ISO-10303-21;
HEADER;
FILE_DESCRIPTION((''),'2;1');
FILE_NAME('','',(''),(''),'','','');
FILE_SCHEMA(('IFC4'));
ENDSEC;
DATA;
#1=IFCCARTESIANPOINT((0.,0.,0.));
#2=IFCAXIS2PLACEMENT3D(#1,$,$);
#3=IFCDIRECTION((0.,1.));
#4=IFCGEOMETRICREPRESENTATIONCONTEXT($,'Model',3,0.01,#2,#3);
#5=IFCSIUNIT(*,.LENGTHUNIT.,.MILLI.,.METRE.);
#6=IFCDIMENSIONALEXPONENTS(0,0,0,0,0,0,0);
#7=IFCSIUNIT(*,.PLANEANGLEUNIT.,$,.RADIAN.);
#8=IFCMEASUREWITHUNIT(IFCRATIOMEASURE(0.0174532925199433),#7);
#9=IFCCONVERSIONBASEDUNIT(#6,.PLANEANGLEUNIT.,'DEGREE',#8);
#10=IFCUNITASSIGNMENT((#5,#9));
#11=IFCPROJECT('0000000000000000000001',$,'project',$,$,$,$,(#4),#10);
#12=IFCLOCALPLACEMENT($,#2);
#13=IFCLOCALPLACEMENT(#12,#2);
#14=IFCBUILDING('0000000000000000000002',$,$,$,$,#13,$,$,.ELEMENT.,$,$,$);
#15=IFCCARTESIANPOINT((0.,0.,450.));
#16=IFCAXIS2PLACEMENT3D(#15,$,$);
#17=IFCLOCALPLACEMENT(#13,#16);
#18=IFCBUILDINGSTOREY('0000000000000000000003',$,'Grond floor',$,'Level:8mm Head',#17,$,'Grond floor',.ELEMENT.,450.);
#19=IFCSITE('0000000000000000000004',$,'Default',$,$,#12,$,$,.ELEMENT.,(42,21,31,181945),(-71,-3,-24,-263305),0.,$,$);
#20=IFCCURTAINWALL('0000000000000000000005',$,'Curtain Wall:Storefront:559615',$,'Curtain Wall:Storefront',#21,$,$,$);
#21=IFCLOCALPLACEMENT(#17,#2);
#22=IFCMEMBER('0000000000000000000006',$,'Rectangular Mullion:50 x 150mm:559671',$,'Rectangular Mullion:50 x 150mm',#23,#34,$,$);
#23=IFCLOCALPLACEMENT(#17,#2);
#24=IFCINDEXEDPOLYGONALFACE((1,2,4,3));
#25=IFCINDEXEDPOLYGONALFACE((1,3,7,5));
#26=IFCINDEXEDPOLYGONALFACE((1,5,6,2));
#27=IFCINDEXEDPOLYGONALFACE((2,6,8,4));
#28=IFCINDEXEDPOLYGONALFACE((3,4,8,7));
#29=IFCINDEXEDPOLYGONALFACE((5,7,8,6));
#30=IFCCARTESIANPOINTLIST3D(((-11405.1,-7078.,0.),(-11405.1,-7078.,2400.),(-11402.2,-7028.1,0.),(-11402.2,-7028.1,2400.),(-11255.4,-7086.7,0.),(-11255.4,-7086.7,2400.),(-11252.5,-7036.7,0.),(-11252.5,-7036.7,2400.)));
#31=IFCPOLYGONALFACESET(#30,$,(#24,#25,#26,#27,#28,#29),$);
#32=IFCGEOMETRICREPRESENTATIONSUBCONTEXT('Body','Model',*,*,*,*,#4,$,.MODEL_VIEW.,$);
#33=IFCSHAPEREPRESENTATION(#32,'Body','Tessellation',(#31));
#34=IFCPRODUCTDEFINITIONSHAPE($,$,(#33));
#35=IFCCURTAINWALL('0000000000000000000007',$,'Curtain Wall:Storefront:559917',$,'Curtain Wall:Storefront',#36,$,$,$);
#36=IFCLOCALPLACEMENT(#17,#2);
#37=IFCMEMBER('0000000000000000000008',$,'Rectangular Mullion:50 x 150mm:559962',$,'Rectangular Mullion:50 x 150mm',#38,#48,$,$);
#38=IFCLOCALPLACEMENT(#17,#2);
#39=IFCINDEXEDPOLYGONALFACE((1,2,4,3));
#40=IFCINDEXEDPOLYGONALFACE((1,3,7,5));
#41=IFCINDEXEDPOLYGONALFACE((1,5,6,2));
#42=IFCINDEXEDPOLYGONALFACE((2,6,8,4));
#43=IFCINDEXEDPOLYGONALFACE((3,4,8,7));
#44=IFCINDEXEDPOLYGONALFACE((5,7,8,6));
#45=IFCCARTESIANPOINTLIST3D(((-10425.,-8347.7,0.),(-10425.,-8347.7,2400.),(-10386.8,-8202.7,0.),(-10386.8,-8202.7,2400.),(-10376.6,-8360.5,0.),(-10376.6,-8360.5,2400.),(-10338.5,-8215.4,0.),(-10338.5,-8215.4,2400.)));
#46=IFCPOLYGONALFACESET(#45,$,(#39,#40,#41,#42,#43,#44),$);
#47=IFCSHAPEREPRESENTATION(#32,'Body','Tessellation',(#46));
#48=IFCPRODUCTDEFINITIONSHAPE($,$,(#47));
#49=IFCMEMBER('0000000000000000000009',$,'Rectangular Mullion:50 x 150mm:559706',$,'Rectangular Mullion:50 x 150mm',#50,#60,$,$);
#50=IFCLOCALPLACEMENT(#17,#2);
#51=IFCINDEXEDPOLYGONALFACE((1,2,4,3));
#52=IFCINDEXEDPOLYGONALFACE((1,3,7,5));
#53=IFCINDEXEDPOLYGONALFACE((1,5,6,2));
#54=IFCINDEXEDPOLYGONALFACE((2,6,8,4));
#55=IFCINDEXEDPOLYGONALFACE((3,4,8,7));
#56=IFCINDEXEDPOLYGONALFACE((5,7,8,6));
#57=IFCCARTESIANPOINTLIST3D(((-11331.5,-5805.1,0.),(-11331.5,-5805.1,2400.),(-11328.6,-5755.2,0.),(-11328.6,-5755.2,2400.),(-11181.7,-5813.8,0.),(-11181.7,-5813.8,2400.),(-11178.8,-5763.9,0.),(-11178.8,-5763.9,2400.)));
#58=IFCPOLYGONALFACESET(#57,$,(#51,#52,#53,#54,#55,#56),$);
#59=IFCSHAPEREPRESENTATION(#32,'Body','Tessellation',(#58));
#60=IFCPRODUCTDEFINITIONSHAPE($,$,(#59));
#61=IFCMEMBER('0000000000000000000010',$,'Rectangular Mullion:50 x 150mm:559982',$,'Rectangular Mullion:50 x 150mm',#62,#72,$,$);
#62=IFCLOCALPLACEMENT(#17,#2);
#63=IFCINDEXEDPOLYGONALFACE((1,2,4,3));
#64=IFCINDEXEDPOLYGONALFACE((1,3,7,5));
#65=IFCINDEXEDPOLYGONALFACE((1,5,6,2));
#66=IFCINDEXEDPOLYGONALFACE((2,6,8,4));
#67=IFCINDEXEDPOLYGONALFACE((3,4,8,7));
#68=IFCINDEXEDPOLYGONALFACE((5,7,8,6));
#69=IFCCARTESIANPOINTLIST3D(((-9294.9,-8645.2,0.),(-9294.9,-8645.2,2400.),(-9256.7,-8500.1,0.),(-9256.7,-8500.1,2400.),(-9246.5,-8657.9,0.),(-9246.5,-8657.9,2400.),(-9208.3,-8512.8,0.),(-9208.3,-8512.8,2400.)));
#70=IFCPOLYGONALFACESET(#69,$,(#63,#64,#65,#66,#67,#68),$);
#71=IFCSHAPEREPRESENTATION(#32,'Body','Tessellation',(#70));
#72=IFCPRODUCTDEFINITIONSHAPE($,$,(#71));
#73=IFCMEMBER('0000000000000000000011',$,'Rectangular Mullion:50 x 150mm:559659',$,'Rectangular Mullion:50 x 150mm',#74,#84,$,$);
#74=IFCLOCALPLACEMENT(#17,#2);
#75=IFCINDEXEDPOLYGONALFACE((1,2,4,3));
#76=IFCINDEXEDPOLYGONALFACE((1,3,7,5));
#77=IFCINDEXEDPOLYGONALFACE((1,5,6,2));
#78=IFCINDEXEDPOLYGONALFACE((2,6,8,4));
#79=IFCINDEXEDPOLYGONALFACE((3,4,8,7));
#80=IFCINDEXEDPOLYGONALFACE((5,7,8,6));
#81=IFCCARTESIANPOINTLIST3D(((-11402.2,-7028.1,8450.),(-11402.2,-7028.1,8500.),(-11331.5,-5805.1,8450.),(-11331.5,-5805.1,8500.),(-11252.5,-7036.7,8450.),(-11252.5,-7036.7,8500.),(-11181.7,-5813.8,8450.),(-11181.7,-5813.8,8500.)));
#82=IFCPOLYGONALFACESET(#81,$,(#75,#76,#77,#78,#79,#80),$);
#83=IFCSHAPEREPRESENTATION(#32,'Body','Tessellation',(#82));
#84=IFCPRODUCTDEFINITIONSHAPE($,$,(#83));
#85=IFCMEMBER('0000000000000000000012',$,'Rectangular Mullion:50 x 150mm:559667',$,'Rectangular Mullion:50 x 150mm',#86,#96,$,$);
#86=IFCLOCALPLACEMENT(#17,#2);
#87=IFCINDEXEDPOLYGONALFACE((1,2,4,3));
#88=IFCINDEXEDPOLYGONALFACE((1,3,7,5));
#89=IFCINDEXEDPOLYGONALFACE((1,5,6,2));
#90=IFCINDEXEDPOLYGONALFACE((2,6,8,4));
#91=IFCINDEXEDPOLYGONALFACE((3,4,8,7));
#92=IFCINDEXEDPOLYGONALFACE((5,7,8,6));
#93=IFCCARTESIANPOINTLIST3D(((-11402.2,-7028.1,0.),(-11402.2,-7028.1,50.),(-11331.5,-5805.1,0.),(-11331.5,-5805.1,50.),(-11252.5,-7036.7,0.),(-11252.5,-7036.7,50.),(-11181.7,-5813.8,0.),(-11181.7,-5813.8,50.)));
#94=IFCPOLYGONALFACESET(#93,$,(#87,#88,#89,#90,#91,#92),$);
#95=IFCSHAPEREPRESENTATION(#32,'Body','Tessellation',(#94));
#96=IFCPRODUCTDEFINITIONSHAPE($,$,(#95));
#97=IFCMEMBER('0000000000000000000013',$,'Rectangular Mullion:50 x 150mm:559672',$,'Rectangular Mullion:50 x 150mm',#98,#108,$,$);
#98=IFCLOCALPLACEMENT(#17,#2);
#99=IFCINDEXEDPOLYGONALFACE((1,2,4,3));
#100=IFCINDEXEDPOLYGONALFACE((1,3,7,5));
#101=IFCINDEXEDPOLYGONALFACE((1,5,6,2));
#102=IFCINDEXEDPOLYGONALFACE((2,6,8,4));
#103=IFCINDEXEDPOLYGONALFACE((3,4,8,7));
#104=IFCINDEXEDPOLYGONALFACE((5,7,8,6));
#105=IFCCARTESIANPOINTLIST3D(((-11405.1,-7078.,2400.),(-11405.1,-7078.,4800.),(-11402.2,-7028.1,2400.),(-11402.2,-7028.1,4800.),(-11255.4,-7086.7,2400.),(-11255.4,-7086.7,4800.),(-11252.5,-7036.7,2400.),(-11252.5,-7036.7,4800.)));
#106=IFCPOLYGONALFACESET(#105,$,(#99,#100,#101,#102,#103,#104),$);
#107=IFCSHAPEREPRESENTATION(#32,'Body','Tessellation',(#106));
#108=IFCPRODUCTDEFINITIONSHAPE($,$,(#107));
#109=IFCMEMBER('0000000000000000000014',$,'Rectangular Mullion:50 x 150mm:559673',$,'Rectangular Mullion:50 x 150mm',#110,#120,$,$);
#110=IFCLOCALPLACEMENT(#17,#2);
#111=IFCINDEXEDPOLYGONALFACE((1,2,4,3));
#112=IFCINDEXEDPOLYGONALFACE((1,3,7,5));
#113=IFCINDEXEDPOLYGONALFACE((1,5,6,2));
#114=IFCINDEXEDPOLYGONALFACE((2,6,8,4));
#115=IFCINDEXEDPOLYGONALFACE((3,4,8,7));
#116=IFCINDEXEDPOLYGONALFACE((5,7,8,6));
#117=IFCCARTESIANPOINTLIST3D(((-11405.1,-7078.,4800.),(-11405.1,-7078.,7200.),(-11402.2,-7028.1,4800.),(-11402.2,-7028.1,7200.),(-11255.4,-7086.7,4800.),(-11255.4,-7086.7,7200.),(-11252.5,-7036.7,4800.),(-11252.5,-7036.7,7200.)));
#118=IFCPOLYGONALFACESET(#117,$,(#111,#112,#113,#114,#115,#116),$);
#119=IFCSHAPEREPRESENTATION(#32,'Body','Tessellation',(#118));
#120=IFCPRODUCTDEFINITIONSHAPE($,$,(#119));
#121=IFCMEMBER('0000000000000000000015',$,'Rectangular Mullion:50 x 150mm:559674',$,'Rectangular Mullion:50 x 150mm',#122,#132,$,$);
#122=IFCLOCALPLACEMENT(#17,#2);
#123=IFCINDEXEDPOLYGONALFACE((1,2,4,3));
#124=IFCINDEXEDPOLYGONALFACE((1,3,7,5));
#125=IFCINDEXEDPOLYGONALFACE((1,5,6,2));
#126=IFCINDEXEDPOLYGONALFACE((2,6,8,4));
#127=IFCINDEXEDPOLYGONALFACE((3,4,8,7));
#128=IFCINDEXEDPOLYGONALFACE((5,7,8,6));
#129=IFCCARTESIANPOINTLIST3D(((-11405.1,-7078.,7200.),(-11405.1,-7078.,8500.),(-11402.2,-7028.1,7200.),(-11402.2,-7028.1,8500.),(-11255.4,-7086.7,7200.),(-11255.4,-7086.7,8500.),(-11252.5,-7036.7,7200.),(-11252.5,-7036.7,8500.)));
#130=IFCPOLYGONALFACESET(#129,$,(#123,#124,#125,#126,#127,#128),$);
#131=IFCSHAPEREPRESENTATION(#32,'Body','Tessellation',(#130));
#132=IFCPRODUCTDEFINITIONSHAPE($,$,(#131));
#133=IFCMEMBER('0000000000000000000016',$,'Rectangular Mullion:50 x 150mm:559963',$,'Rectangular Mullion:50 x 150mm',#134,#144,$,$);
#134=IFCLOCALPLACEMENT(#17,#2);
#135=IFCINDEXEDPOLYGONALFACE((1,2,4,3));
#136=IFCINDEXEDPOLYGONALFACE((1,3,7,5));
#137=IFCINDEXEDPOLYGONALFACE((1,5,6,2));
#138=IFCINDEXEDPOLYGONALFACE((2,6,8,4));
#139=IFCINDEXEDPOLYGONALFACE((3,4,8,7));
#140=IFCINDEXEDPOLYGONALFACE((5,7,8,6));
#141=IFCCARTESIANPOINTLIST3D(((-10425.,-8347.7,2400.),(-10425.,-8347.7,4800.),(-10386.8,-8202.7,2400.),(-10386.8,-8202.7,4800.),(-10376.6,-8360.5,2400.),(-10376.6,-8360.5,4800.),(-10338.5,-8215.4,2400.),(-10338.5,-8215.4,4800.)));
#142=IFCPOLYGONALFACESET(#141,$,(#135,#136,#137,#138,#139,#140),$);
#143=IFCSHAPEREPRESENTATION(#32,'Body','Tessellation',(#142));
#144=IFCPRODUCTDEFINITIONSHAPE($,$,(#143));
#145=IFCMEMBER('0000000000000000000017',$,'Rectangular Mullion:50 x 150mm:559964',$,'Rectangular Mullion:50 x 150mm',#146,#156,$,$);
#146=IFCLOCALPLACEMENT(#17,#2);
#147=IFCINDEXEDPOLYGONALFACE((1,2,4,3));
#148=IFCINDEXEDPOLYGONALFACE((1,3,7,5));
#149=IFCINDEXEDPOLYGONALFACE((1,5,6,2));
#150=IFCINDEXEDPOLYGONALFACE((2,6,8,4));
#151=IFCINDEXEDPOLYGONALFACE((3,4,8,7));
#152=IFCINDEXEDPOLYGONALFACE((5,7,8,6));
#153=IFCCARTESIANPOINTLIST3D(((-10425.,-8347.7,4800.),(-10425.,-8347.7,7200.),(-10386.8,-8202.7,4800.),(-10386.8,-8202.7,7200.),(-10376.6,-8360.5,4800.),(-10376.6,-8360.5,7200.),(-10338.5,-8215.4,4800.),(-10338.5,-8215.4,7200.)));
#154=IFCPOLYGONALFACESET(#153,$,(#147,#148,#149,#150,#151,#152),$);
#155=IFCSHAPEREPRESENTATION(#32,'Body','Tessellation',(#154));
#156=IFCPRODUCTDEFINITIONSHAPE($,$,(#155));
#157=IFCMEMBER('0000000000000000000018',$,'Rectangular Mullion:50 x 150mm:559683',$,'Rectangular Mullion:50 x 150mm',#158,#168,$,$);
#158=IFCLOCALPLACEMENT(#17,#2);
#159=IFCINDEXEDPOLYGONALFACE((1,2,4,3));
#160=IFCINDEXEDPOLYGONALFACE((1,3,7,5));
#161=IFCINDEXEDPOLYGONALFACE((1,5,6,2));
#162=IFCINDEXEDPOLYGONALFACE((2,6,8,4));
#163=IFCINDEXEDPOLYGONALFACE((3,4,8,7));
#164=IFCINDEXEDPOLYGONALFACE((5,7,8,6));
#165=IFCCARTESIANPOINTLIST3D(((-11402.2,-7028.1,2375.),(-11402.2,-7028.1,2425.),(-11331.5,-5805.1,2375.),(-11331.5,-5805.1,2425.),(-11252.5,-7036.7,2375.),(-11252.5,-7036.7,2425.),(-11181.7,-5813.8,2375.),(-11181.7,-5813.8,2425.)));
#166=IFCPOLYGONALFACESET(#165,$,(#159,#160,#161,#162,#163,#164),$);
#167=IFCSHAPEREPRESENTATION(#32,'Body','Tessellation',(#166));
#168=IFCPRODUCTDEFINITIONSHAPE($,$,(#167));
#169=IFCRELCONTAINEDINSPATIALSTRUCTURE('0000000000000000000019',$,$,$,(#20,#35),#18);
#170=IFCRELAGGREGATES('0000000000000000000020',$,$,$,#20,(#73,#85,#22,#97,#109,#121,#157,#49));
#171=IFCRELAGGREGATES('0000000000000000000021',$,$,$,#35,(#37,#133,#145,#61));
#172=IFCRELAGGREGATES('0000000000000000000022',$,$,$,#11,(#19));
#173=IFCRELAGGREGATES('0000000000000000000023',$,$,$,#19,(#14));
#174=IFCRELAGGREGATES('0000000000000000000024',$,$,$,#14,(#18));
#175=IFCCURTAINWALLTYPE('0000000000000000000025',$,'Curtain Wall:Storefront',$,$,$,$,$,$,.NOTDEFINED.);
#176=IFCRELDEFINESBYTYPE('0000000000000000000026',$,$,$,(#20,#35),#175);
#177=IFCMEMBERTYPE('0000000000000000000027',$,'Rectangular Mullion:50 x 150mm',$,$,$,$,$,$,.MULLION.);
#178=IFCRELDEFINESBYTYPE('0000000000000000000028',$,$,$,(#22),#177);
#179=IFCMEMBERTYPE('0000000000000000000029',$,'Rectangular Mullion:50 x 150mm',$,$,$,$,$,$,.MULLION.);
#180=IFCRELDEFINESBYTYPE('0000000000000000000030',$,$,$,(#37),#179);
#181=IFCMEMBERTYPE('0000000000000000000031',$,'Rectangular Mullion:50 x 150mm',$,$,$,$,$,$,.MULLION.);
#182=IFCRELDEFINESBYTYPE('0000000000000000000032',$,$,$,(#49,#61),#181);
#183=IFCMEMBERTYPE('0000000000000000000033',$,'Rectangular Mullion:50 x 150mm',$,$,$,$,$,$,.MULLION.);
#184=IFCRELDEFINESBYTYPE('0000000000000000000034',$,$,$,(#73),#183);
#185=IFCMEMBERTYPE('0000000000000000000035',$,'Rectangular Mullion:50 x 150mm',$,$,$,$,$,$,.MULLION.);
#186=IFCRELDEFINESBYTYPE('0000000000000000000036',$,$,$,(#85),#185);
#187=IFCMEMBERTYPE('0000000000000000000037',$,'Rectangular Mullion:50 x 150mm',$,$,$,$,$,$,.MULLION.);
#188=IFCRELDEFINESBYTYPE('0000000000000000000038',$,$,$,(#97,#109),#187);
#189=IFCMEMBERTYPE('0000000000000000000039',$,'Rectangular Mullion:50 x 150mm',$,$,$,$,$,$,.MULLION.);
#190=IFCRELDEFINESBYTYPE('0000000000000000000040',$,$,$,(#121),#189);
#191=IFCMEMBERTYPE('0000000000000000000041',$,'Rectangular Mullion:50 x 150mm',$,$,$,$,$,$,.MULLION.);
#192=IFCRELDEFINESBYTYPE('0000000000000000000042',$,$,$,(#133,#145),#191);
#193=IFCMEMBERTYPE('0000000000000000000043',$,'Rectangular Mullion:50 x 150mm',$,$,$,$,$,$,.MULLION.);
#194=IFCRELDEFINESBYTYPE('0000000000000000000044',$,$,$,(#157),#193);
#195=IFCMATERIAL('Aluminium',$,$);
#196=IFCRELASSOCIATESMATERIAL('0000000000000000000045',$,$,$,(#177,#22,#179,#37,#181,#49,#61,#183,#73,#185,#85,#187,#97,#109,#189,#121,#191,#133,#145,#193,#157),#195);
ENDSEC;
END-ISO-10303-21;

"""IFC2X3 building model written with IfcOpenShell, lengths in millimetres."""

from ifc_helpers import new_model, entity, si_unit, converted_unit, direction, frame, origin, origin_2d_with_axis, place, context, subcontext, project, spatial, rectangle, extrude, source, transform, mapped, material, type_object, type_shapes, element, aggregate, save


model = new_model("IFC2X3")

# Units and contexts
model_context = context("Model", 3, precision=0.01, world=origin(), true_north=direction((0.0, 1.0)))
body_context = subcontext(model_context, "Body", "Model", "MODEL_VIEW")
ifc_project = project(units=[si_unit("LENGTHUNIT", "METRE", prefix="MILLI"), converted_unit("PLANEANGLEUNIT", "DEGREE", entity("IfcRatioMeasure", 0.0174532925199433), si_unit("PLANEANGLEUNIT", "RADIAN"), dimensions=[0, 0, 0, 0, 0, 0, 0])], contexts=[model_context])

# Site, building, storey
site_placement = place(None, origin())
site = spatial("IfcSite", under=ifc_project, at=site_placement, Name="Default", CompositionType="ELEMENT", RefLatitude=(42, 21, 31, 181945), RefLongitude=(-71, -3, -24, -263305), RefElevation=0.0)
building_placement = place(site_placement, origin())
building = spatial("IfcBuilding", under=site, at=building_placement, CompositionType="ELEMENT")
storey_placement = place(building_placement, frame((0.0, 0.0, 450.0)))
storey = spatial("IfcBuildingStorey", under=building, at=storey_placement, Name="Grond floor", ObjectType="Level:8mm Head", LongName="Grond floor", CompositionType="ELEMENT", Elevation=450.0)

# Curtain walls, members
curtain_wall_type = type_object("IfcCurtainWallType", Name="Curtain Wall:Storefront", PredefinedType="NOTDEFINED")
curtain_wall_1_placement = place(storey_placement, frame((0.0, 0.0, -450.0)))
curtain_wall_1 = element("IfcCurtainWall", 1, at=curtain_wall_1_placement, inside=storey, type_object=curtain_wall_type, Name="Curtain Wall:Storefront:559615", ObjectType="Curtain Wall:Storefront")
ifc_material_1 = material(Name="Aluminium")
member_type_1 = type_object("IfcMemberType", Name="Rectangular Mullion:50 x 150mm", PredefinedType="MULLION", material=ifc_material_1)
shared_shape_1 = source(origin(), body_context, "Body", "SweptSolid", [
    extrude(rectangle(XDim=150.0, YDim=50.0, at=origin_2d_with_axis()), frame((-25.0, 0.0, -2400.0), z_axis=(0.0, 0.0, 1.0), x_axis=(0.0, -1.0, 0.0)), (0.0, 0.0, 1.0), 2400.0),
])
type_shapes(member_type_1, [shared_shape_1])
member_1_placement = place(storey_placement, frame((-11330.2, -7082.3, 0.0), z_axis=(0.0, 0.0, -1.0), x_axis=(-0.057751, -0.998331, 0.0)))
member_1 = element("IfcMember", 2, at=member_1_placement, type_object=member_type_1, material=ifc_material_1, Name="Rectangular Mullion:50 x 150mm:559671", ObjectType="Rectangular Mullion:50 x 150mm", context=body_context, shape_type="MappedRepresentation", body=[
    mapped(shared_shape_1, transform((0.0, 0.0, 0.0), scale=1.0)),
])
curtain_wall_2_placement = place(storey_placement, frame((0.0, 0.0, -450.0)))
curtain_wall_2 = element("IfcCurtainWall", 3, at=curtain_wall_2_placement, inside=storey, type_object=curtain_wall_type, Name="Curtain Wall:Storefront:559917", ObjectType="Curtain Wall:Storefront")
member_type_2 = type_object("IfcMemberType", Name="Rectangular Mullion:50 x 150mm", PredefinedType="MULLION", material=ifc_material_1)
shared_shape_2 = source(origin(), body_context, "Body", "SweptSolid", [
    extrude(rectangle(XDim=150.0, YDim=50.0, at=origin_2d_with_axis()), frame((-25.0, 0.0, -2400.0), z_axis=(0.0, 0.0, 1.0), x_axis=(0.0, -1.0, 0.0)), (0.0, 0.0, 1.0), 2400.0),
])
type_shapes(member_type_2, [shared_shape_2])
member_2_placement = place(storey_placement, frame((-10405.9, -8275.2, 2400.0), z_axis=(0.0, 0.0, 1.0), x_axis=(-0.967067, 0.25452, 0.0)))
member_2 = element("IfcMember", 4, at=member_2_placement, type_object=member_type_2, material=ifc_material_1, Name="Rectangular Mullion:50 x 150mm:559962", ObjectType="Rectangular Mullion:50 x 150mm", context=body_context, shape_type="MappedRepresentation", body=[
    mapped(shared_shape_2, transform((0.0, 0.0, 0.0), scale=1.0)),
])

# Members
member_type_3 = type_object("IfcMemberType", Name="Rectangular Mullion:50 x 150mm", PredefinedType="MULLION", material=ifc_material_1)
shared_shape_3 = source(origin(), body_context, "Body", "SweptSolid", [
    extrude(rectangle(XDim=150.0, YDim=50.0, at=origin_2d_with_axis()), frame((0.0, 0.0, -2400.0), z_axis=(0.0, 0.0, 1.0), x_axis=(0.0, -1.0, 0.0)), (0.0, 0.0, 1.0), 2400.0),
])
type_shapes(member_type_3, [shared_shape_3])
member_3_placement = place(storey_placement, frame((-11255.2, -5784.5, 0.0), z_axis=(0.0, 0.0, -1.0), x_axis=(-0.057751, -0.998331, 0.0)))
member_3 = element("IfcMember", 5, at=member_3_placement, type_object=member_type_3, material=ifc_material_1, Name="Rectangular Mullion:50 x 150mm:559706", ObjectType="Rectangular Mullion:50 x 150mm", context=body_context, shape_type="MappedRepresentation", body=[
    mapped(shared_shape_3, transform((0.0, 0.0, 0.0), scale=1.0)),
])
member_4_placement = place(storey_placement, frame((-9251.6, -8579.0, 0.0), z_axis=(0.0, 0.0, -1.0), x_axis=(0.967067, -0.25452, 0.0)))
member_4 = element("IfcMember", 6, at=member_4_placement, type_object=member_type_3, material=ifc_material_1, Name="Rectangular Mullion:50 x 150mm:559982", ObjectType="Rectangular Mullion:50 x 150mm", context=body_context, shape_type="MappedRepresentation", body=[
    mapped(shared_shape_3, transform((0.0, 0.0, 0.0), scale=1.0)),
])
member_type_4 = type_object("IfcMemberType", Name="Rectangular Mullion:50 x 150mm", PredefinedType="MULLION", material=ifc_material_1)
shared_shape_4 = source(origin(), body_context, "Body", "SweptSolid", [
    extrude(rectangle(XDim=150.0, YDim=50.0, at=origin_2d_with_axis()), frame((-25.0, 0.0, -1225.0), z_axis=(0.0, 0.0, 1.0), x_axis=(0.0, -1.0, 0.0)), (0.0, 0.0, 1.0), 1225.0),
])
type_shapes(member_type_4, [shared_shape_4])
member_5_placement = place(storey_placement, frame((-11327.4, -7032.4, 8500.0), z_axis=(-0.057751, -0.998331, 0.0), x_axis=(0.0, 0.0, 1.0)))
member_5 = element("IfcMember", 7, at=member_5_placement, type_object=member_type_4, material=ifc_material_1, Name="Rectangular Mullion:50 x 150mm:559659", ObjectType="Rectangular Mullion:50 x 150mm", context=body_context, shape_type="MappedRepresentation", body=[
    mapped(shared_shape_4, transform((0.0, 0.0, 0.0), scale=1.0)),
])
member_type_5 = type_object("IfcMemberType", Name="Rectangular Mullion:50 x 150mm", PredefinedType="MULLION", material=ifc_material_1)
shared_shape_5 = source(origin(), body_context, "Body", "SweptSolid", [
    extrude(rectangle(XDim=150.0, YDim=50.0, at=origin_2d_with_axis()), frame((-25.0, 0.0, -1225.0), z_axis=(0.0, 0.0, 1.0), x_axis=(0.0, -1.0, 0.0)), (0.0, 0.0, 1.0), 1225.0),
])
type_shapes(member_type_5, [shared_shape_5])
member_6_placement = place(storey_placement, frame((-11256.6, -5809.4, 0.0), z_axis=(0.057751, 0.998331, 0.0), x_axis=(0.0, 0.0, -1.0)))
member_6 = element("IfcMember", 8, at=member_6_placement, type_object=member_type_5, material=ifc_material_1, Name="Rectangular Mullion:50 x 150mm:559667", ObjectType="Rectangular Mullion:50 x 150mm", context=body_context, shape_type="MappedRepresentation", body=[
    mapped(shared_shape_5, transform((0.0, 0.0, 0.0), scale=1.0)),
])
member_type_6 = type_object("IfcMemberType", Name="Rectangular Mullion:50 x 150mm", PredefinedType="MULLION", material=ifc_material_1)
shared_shape_6 = source(origin(), body_context, "Body", "SweptSolid", [
    extrude(rectangle(XDim=150.0, YDim=50.0, at=origin_2d_with_axis()), frame((-25.0, 0.0, -2400.0), z_axis=(0.0, 0.0, 1.0), x_axis=(0.0, -1.0, 0.0)), (0.0, 0.0, 1.0), 2400.0),
])
type_shapes(member_type_6, [shared_shape_6])
member_7_placement = place(storey_placement, frame((-11330.2, -7082.3, 2400.0), z_axis=(0.0, 0.0, -1.0), x_axis=(-0.057751, -0.998331, 0.0)))
member_7 = element("IfcMember", 9, at=member_7_placement, type_object=member_type_6, material=ifc_material_1, Name="Rectangular Mullion:50 x 150mm:559672", ObjectType="Rectangular Mullion:50 x 150mm", context=body_context, shape_type="MappedRepresentation", body=[
    mapped(shared_shape_6, transform((0.0, 0.0, 0.0), scale=1.0)),
])
member_8_placement = place(storey_placement, frame((-11330.2, -7082.3, 4800.0), z_axis=(0.0, 0.0, -1.0), x_axis=(-0.057751, -0.998331, 0.0)))
member_8 = element("IfcMember", 10, at=member_8_placement, type_object=member_type_6, material=ifc_material_1, Name="Rectangular Mullion:50 x 150mm:559673", ObjectType="Rectangular Mullion:50 x 150mm", context=body_context, shape_type="MappedRepresentation", body=[
    mapped(shared_shape_6, transform((0.0, 0.0, 0.0), scale=1.0)),
])
member_type_7 = type_object("IfcMemberType", Name="Rectangular Mullion:50 x 150mm", PredefinedType="MULLION", material=ifc_material_1)
shared_shape_7 = source(origin(), body_context, "Body", "SweptSolid", [
    extrude(rectangle(XDim=150.0, YDim=50.0, at=origin_2d_with_axis()), frame((-25.0, 0.0, -1300.0), z_axis=(0.0, 0.0, 1.0), x_axis=(0.0, -1.0, 0.0)), (0.0, 0.0, 1.0), 1300.0),
])
type_shapes(member_type_7, [shared_shape_7])
member_9_placement = place(storey_placement, frame((-11330.2, -7082.3, 7200.0), z_axis=(0.0, 0.0, -1.0), x_axis=(-0.057751, -0.998331, 0.0)))
member_9 = element("IfcMember", 11, at=member_9_placement, type_object=member_type_7, material=ifc_material_1, Name="Rectangular Mullion:50 x 150mm:559674", ObjectType="Rectangular Mullion:50 x 150mm", context=body_context, shape_type="MappedRepresentation", body=[
    mapped(shared_shape_7, transform((0.0, 0.0, 0.0), scale=1.0)),
])
member_type_8 = type_object("IfcMemberType", Name="Rectangular Mullion:50 x 150mm", PredefinedType="MULLION", material=ifc_material_1)
shared_shape_8 = source(origin(), body_context, "Body", "SweptSolid", [
    extrude(rectangle(XDim=150.0, YDim=50.0, at=origin_2d_with_axis()), frame((-25.0, 0.0, -2400.0), z_axis=(0.0, 0.0, 1.0), x_axis=(0.0, -1.0, 0.0)), (0.0, 0.0, 1.0), 2400.0),
])
type_shapes(member_type_8, [shared_shape_8])
member_10_placement = place(storey_placement, frame((-10405.9, -8275.2, 4800.0), z_axis=(0.0, 0.0, 1.0), x_axis=(-0.967067, 0.25452, 0.0)))
member_10 = element("IfcMember", 12, at=member_10_placement, type_object=member_type_8, material=ifc_material_1, Name="Rectangular Mullion:50 x 150mm:559963", ObjectType="Rectangular Mullion:50 x 150mm", context=body_context, shape_type="MappedRepresentation", body=[
    mapped(shared_shape_8, transform((0.0, 0.0, 0.0), scale=1.0)),
])
member_11_placement = place(storey_placement, frame((-10405.9, -8275.2, 7200.0), z_axis=(0.0, 0.0, 1.0), x_axis=(-0.967067, 0.25452, 0.0)))
member_11 = element("IfcMember", 13, at=member_11_placement, type_object=member_type_8, material=ifc_material_1, Name="Rectangular Mullion:50 x 150mm:559964", ObjectType="Rectangular Mullion:50 x 150mm", context=body_context, shape_type="MappedRepresentation", body=[
    mapped(shared_shape_8, transform((0.0, 0.0, 0.0), scale=1.0)),
])
member_type_9 = type_object("IfcMemberType", Name="Rectangular Mullion:50 x 150mm", PredefinedType="MULLION", material=ifc_material_1)
shared_shape_9 = source(origin(), body_context, "Body", "SweptSolid", [
    extrude(rectangle(XDim=150.0, YDim=50.0, at=origin_2d_with_axis()), frame((0.0, 0.0, -1225.0), z_axis=(0.0, 0.0, 1.0), x_axis=(0.0, -1.0, 0.0)), (0.0, 0.0, 1.0), 1225.0),
])
type_shapes(member_type_9, [shared_shape_9])
member_12_placement = place(storey_placement, frame((-11327.4, -7032.4, 2400.0), z_axis=(-0.057751, -0.998331, 0.0), x_axis=(0.0, 0.0, 1.0)))
member_12 = element("IfcMember", 14, at=member_12_placement, type_object=member_type_9, material=ifc_material_1, Name="Rectangular Mullion:50 x 150mm:559683", ObjectType="Rectangular Mullion:50 x 150mm", context=body_context, shape_type="MappedRepresentation", body=[
    mapped(shared_shape_9, transform((0.0, 0.0, 0.0), scale=1.0)),
])

aggregate(curtain_wall_1, [member_5, member_6, member_1, member_7, member_8, member_9, member_12, member_3])
aggregate(curtain_wall_2, [member_2, member_10, member_11, member_4])

save(model, "model.ifc")
